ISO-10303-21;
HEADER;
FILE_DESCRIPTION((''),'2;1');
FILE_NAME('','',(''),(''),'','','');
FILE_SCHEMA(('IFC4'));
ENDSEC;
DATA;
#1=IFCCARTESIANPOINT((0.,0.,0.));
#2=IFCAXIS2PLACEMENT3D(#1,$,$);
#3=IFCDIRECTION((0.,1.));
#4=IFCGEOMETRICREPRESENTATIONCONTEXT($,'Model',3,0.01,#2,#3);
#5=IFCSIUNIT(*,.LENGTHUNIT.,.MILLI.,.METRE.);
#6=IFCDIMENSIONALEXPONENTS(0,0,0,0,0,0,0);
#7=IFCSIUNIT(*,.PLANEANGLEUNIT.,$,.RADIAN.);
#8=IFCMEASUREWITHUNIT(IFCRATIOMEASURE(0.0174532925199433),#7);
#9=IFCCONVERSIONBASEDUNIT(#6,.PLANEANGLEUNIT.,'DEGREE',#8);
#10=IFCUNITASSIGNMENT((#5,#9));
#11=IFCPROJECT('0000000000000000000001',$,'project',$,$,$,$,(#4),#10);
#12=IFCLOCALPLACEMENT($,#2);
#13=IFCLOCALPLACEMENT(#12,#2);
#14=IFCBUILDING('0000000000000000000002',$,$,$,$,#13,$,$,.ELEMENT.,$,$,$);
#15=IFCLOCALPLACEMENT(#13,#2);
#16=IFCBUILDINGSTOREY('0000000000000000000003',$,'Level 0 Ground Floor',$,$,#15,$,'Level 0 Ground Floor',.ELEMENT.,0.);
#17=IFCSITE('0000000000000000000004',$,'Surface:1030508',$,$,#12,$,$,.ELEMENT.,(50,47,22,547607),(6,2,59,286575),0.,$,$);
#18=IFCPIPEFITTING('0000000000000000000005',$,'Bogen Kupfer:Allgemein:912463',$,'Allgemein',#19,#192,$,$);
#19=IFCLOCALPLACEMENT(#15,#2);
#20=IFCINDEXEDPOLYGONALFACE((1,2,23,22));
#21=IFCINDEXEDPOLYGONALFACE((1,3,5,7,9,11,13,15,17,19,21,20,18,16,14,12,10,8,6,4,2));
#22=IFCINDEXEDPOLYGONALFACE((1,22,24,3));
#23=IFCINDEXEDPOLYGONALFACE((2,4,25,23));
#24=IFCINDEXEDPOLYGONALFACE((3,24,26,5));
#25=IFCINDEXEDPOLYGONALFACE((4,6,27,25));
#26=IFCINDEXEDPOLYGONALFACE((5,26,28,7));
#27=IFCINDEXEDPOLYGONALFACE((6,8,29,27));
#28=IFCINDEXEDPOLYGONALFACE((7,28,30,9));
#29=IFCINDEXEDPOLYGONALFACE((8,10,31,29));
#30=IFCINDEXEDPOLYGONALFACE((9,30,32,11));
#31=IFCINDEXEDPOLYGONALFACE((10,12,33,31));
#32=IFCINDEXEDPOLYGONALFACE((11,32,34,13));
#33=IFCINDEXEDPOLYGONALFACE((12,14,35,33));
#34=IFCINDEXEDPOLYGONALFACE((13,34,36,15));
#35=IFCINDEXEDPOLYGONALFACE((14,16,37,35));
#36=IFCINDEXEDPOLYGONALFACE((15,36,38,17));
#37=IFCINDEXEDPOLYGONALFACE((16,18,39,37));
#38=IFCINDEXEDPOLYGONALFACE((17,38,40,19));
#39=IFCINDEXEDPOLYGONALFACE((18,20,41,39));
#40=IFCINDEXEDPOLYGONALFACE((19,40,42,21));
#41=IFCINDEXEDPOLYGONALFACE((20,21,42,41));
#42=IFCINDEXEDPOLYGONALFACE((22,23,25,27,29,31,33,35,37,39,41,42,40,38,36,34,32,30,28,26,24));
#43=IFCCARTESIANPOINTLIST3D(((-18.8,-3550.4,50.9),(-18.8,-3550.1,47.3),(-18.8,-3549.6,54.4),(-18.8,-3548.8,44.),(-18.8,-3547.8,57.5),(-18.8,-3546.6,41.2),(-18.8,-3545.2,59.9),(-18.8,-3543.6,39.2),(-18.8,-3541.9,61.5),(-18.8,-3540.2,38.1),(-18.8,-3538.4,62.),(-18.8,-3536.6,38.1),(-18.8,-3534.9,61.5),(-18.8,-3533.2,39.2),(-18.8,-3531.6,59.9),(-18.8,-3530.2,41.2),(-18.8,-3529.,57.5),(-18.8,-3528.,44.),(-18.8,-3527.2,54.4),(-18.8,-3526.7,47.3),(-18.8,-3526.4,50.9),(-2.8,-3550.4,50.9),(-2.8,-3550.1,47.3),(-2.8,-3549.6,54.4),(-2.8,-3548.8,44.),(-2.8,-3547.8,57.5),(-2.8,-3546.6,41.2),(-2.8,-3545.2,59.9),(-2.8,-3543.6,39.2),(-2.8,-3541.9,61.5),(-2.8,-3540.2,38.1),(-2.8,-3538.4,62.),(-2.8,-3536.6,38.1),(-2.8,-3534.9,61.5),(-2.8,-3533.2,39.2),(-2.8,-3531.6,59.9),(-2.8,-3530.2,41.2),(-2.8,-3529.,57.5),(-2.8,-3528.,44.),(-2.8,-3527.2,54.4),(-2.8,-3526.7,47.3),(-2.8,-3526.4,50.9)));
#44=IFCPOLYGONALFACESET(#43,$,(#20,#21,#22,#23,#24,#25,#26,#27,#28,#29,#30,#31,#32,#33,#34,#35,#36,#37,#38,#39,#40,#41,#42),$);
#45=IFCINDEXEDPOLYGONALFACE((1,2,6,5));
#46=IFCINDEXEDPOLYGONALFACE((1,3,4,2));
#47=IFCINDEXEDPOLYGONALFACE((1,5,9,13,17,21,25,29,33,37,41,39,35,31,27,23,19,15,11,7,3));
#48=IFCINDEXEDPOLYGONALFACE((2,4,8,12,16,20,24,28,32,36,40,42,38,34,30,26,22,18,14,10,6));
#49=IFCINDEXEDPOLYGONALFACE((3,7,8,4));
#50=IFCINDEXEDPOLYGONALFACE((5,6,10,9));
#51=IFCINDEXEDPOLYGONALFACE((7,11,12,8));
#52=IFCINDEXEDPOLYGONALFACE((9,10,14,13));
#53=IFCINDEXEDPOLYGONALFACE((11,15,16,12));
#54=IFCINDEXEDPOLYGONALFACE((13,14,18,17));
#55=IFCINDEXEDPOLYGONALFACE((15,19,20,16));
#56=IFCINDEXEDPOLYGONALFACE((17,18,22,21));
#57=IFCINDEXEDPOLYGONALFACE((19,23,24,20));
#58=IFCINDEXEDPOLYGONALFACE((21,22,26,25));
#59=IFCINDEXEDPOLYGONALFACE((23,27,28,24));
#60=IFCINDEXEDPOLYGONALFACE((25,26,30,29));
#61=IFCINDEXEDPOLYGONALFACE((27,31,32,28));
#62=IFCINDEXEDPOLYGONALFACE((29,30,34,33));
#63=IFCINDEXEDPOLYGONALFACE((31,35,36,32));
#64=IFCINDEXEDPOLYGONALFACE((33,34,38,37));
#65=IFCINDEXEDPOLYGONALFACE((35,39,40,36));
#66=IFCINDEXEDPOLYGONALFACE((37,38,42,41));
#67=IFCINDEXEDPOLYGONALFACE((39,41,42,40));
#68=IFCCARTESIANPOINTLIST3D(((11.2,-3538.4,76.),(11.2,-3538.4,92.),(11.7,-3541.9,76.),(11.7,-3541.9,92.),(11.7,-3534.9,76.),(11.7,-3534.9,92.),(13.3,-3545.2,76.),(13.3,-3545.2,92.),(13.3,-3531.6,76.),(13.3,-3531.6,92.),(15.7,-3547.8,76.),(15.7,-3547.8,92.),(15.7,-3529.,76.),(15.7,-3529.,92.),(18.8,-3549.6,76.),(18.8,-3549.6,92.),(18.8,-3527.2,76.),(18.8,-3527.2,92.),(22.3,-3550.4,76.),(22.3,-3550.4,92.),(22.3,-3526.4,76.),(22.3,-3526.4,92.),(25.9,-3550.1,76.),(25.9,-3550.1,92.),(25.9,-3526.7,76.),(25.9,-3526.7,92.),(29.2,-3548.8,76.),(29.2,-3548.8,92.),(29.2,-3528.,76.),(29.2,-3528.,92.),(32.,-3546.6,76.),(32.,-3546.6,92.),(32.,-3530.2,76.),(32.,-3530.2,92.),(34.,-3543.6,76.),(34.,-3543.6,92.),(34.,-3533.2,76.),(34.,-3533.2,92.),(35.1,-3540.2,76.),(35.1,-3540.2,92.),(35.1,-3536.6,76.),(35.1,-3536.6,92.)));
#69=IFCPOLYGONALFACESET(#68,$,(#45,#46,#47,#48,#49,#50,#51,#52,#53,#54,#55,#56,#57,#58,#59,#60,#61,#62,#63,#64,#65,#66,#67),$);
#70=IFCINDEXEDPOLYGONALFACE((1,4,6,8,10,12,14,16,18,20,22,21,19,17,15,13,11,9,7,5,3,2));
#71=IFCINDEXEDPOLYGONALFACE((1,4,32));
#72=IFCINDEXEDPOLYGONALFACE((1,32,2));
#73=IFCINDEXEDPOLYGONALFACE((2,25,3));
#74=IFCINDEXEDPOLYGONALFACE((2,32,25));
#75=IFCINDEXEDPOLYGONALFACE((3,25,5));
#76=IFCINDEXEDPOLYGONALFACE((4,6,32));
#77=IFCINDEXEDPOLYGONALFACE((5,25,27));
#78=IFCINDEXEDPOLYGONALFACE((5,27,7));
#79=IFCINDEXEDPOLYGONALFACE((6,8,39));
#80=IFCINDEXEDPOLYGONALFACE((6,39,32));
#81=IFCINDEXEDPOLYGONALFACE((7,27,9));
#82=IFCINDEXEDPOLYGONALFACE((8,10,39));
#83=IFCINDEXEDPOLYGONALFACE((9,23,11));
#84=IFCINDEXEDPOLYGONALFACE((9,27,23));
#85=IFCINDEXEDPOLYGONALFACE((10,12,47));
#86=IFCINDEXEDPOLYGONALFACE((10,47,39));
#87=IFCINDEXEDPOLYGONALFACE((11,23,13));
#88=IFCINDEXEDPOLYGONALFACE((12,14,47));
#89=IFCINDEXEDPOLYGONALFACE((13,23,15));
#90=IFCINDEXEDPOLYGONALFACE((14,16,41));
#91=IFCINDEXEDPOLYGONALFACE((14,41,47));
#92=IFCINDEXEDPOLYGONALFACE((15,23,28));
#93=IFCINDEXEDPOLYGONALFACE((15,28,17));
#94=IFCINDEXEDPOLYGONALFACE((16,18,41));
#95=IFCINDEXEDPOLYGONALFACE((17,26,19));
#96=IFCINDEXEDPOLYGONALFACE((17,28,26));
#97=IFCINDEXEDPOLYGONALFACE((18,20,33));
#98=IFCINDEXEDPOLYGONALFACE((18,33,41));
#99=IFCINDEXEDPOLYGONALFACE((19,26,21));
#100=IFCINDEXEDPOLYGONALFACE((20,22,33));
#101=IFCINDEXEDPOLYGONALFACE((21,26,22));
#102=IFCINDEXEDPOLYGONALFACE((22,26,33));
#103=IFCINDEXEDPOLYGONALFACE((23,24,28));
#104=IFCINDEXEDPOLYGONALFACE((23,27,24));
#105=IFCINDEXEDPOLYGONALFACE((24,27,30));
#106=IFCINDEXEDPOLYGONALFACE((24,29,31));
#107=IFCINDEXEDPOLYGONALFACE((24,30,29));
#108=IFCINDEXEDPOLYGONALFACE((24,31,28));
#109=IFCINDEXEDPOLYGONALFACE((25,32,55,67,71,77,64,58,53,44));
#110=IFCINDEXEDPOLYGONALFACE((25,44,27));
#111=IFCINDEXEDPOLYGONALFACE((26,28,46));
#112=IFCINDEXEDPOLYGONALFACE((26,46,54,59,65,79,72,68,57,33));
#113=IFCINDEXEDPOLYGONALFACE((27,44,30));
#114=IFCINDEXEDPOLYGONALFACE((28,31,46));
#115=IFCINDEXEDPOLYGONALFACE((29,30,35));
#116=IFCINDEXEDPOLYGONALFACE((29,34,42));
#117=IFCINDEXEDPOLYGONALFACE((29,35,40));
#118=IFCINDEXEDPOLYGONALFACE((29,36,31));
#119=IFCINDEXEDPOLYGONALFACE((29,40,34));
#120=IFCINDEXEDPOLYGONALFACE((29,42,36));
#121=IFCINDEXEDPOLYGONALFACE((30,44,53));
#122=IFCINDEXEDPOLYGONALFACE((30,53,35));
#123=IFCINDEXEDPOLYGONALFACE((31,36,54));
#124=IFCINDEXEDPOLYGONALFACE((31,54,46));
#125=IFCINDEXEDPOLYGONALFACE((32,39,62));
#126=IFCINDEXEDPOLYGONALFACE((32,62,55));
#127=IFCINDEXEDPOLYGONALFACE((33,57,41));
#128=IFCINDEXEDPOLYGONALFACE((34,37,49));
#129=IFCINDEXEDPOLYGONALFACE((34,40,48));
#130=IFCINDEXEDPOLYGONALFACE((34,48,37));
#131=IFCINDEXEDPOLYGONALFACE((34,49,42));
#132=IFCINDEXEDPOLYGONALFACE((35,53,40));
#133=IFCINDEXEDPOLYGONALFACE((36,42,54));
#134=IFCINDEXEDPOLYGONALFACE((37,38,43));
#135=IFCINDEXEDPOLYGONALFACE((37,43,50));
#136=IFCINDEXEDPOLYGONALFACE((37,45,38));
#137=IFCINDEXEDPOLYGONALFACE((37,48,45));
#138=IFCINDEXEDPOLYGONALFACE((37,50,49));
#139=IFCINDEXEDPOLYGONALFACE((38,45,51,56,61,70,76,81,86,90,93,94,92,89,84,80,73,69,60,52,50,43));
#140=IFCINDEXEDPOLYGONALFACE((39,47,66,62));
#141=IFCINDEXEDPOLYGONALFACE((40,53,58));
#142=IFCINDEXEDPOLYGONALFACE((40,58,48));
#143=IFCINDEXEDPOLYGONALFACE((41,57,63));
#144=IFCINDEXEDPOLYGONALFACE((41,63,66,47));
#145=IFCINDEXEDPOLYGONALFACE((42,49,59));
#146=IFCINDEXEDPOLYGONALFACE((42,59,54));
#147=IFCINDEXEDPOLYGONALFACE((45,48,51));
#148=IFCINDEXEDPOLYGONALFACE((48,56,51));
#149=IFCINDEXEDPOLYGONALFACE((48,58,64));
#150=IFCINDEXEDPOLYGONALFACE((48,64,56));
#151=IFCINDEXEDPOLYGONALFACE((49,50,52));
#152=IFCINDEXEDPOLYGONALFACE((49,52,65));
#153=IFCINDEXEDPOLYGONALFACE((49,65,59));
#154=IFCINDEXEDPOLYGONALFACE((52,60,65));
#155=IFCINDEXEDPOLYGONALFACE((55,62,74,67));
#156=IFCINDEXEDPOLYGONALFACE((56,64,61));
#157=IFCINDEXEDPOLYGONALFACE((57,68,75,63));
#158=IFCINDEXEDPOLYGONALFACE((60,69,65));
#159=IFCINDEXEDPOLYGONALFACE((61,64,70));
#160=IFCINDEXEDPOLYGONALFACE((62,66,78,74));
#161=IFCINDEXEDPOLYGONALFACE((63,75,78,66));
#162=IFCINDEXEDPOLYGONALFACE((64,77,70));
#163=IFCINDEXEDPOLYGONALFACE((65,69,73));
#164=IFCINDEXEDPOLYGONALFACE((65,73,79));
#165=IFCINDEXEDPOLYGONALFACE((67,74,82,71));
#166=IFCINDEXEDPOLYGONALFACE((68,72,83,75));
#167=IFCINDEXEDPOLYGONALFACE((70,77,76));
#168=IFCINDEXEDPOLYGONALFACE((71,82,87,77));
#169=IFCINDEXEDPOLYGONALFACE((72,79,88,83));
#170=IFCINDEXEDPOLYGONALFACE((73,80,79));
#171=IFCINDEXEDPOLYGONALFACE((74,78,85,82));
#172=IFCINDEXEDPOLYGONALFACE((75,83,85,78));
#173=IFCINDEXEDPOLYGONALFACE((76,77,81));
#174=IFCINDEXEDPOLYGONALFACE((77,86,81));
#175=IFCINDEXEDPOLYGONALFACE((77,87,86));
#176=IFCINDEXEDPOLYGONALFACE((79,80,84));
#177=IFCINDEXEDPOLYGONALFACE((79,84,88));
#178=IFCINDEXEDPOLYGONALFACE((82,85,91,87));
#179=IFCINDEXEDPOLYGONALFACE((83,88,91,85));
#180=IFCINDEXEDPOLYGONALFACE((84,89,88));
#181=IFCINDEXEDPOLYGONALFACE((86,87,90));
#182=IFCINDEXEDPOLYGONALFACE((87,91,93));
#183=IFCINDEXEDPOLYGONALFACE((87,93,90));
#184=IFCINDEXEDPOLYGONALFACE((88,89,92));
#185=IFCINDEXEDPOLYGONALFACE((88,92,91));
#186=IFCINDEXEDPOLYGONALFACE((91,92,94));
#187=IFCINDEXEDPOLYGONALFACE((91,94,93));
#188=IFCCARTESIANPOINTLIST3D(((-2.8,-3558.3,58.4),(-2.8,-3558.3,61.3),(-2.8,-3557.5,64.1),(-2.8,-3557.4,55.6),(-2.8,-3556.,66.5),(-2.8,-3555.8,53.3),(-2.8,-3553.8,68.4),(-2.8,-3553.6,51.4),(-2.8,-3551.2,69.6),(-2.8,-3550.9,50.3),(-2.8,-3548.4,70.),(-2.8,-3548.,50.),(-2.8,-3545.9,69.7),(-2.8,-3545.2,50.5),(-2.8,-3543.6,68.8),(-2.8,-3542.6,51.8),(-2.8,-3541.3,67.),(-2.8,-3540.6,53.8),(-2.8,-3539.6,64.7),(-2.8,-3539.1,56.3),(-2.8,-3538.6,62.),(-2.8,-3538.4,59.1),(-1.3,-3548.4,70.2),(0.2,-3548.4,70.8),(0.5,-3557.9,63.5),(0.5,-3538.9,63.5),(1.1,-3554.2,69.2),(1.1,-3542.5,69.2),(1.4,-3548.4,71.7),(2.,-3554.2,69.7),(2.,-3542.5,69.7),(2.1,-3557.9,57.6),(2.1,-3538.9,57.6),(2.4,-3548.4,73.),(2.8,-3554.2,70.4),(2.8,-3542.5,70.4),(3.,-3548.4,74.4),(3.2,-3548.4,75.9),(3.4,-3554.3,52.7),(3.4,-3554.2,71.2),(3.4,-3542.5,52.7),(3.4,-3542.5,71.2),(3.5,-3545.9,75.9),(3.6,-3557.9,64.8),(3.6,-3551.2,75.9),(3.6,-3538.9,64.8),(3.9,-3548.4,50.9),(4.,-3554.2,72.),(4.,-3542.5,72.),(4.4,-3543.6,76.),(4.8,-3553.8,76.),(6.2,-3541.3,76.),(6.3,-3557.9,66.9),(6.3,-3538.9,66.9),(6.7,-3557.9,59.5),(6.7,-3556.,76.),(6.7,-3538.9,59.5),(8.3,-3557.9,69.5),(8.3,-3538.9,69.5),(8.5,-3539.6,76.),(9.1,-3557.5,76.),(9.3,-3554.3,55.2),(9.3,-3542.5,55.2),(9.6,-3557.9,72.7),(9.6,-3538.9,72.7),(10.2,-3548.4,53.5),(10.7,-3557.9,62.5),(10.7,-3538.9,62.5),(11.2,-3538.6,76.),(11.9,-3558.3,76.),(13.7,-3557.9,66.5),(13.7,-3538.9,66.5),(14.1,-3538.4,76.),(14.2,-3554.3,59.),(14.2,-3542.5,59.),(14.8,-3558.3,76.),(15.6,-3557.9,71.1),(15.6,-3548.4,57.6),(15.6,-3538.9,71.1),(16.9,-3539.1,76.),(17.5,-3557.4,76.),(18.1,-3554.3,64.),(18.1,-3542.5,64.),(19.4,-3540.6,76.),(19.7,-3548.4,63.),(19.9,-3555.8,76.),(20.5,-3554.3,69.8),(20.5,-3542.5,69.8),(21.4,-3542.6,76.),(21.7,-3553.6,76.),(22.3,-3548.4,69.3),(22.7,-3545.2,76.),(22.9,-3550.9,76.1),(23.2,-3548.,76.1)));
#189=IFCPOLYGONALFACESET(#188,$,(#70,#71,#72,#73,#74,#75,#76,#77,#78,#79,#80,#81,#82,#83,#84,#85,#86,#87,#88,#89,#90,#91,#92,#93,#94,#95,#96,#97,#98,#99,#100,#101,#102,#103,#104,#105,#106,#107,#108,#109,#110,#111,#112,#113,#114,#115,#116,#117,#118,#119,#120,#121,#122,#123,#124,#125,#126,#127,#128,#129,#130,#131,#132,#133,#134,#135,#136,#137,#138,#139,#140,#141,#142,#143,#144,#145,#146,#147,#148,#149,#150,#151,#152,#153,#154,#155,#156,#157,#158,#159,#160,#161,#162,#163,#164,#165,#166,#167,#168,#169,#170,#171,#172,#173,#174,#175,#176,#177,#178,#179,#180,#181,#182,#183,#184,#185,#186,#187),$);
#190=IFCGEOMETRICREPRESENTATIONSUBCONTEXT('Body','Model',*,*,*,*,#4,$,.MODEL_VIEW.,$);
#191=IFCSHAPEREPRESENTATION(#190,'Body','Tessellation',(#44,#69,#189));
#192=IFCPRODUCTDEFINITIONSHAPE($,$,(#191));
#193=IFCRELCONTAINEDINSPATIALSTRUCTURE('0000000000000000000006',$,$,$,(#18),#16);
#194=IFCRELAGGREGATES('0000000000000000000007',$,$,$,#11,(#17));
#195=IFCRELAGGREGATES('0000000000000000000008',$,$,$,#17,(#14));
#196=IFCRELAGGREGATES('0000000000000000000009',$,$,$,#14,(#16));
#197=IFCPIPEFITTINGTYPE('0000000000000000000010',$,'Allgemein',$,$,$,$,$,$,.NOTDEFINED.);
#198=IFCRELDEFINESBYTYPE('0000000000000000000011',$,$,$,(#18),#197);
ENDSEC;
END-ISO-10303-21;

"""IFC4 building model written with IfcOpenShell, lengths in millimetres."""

from ifc_helpers import new_model, entity, si_unit, converted_unit, direction, frame, frame_2d, origin, place, context, subcontext, project, spatial, circle, extrude, source, transform, mapped, type_object, type_shapes, element, save


model = new_model("IFC4")

# Units and contexts
model_context = context("Model", 3, precision=0.01, world=origin(), true_north=direction((0.0, 1.0)))
body_context = subcontext(model_context, "Body", "Model", "MODEL_VIEW")
ifc_project = project(units=[si_unit("LENGTHUNIT", "METRE", prefix="MILLI"), converted_unit("PLANEANGLEUNIT", "DEGREE", entity("IfcRatioMeasure", 0.0174532925199433), si_unit("PLANEANGLEUNIT", "RADIAN"), dimensions=[0, 0, 0, 0, 0, 0, 0])], contexts=[model_context])

# Site, building, storey
site_placement = place(None, origin())
site = spatial("IfcSite", under=ifc_project, at=site_placement, Name="Surface:1030508", CompositionType="ELEMENT", RefLatitude=(50, 47, 22, 547607), RefLongitude=(6, 2, 59, 286575), RefElevation=0.0)
building_placement = place(site_placement, origin())
building = spatial("IfcBuilding", under=site, at=building_placement, CompositionType="ELEMENT")
storey_placement = place(building_placement, origin())
storey = spatial("IfcBuildingStorey", under=building, at=storey_placement, Name="Level 0 Ground Floor", LongName="Level 0 Ground Floor", CompositionType="ELEMENT", Elevation=0.0)

# Pipe fitting
pipe_fitting_type_1 = type_object("IfcPipeFittingType", Name="Allgemein", PredefinedType="NOTDEFINED")
ifc_direction_1 = entity("IfcDirection", [0.0, 0.0, -1.0])
trimmed_curve_1 = entity("IfcTrimmedCurve", entity("IfcCircle", entity("IfcAxis2Placement2D", entity("IfcCartesianPoint", [-16.0, 0.0]), entity("IfcDirection", [0.0, 1.0])), 16.0), [entity("IfcParameterValue", 270.0)], [entity("IfcParameterValue", 0.0)], True, "PARAMETER")
shared_shape_1 = source(origin(), body_context, "Body", "SolidModel", [
    extrude(circle(Radius=12.0, at=frame_2d((0.0, 0.0), x_axis=(1.0, 0.0))), frame((0.0, 26.0, 0.0), z_axis=(0.0, 1.0, 0.0), x_axis=(-1.0, 0.0, 0.0)), (0.0, 0.0, 1.0), 16.0),
    extrude(circle(Radius=12.0, at=frame_2d((0.0, 0.0), x_axis=(1.0, 0.0))), frame((-42.0, 0.0, 0.0), z_axis=(1.0, 0.0, 0.0), x_axis=(0.0, 1.0, 0.0)), (0.0, 0.0, 1.0), 16.0),
    entity("IfcSurfaceCurveSweptAreaSolid", entity("IfcCircleProfileDef", "AREA", None, entity("IfcAxis2Placement2D", entity("IfcCartesianPoint", [0.0, 10.0]), entity("IfcDirection", [1.0, 0.0])), 10.0), entity("IfcAxis2Placement3D", entity("IfcCartesianPoint", [-10.0, 26.0, 0.0]), ifc_direction_1, entity("IfcDirection", [1.0, 0.0, 0.0])), trimmed_curve_1, 0.0, 90.0, entity("IfcSurfaceOfLinearExtrusion", entity("IfcArbitraryOpenProfileDef", "CURVE", None, trimmed_curve_1), entity("IfcAxis2Placement3D", entity("IfcCartesianPoint", [0.0, 0.0, -304.8])), ifc_direction_1, 1.0)),
])
type_shapes(pipe_fitting_type_1, [shared_shape_1])
for number, where, z_axis, x_axis, name in (
    (1, (23.2, -3538.4, 50.0), (0.0, 1.0, 0.0), (0.0, 0.0, -1.0), "Bogen Kupfer:Allgemein:912463"),
):
    element("IfcPipeFitting", number, at=place(storey_placement, frame(where, z_axis=z_axis, x_axis=x_axis)), inside=storey, type_object=pipe_fitting_type_1, Name=name, ObjectType="Allgemein", context=body_context, shape_type="MappedRepresentation", body=[
        mapped(shared_shape_1, transform((0.0, 0.0, 0.0), scale=1.0)),
    ])

save(model, "model.ifc")
